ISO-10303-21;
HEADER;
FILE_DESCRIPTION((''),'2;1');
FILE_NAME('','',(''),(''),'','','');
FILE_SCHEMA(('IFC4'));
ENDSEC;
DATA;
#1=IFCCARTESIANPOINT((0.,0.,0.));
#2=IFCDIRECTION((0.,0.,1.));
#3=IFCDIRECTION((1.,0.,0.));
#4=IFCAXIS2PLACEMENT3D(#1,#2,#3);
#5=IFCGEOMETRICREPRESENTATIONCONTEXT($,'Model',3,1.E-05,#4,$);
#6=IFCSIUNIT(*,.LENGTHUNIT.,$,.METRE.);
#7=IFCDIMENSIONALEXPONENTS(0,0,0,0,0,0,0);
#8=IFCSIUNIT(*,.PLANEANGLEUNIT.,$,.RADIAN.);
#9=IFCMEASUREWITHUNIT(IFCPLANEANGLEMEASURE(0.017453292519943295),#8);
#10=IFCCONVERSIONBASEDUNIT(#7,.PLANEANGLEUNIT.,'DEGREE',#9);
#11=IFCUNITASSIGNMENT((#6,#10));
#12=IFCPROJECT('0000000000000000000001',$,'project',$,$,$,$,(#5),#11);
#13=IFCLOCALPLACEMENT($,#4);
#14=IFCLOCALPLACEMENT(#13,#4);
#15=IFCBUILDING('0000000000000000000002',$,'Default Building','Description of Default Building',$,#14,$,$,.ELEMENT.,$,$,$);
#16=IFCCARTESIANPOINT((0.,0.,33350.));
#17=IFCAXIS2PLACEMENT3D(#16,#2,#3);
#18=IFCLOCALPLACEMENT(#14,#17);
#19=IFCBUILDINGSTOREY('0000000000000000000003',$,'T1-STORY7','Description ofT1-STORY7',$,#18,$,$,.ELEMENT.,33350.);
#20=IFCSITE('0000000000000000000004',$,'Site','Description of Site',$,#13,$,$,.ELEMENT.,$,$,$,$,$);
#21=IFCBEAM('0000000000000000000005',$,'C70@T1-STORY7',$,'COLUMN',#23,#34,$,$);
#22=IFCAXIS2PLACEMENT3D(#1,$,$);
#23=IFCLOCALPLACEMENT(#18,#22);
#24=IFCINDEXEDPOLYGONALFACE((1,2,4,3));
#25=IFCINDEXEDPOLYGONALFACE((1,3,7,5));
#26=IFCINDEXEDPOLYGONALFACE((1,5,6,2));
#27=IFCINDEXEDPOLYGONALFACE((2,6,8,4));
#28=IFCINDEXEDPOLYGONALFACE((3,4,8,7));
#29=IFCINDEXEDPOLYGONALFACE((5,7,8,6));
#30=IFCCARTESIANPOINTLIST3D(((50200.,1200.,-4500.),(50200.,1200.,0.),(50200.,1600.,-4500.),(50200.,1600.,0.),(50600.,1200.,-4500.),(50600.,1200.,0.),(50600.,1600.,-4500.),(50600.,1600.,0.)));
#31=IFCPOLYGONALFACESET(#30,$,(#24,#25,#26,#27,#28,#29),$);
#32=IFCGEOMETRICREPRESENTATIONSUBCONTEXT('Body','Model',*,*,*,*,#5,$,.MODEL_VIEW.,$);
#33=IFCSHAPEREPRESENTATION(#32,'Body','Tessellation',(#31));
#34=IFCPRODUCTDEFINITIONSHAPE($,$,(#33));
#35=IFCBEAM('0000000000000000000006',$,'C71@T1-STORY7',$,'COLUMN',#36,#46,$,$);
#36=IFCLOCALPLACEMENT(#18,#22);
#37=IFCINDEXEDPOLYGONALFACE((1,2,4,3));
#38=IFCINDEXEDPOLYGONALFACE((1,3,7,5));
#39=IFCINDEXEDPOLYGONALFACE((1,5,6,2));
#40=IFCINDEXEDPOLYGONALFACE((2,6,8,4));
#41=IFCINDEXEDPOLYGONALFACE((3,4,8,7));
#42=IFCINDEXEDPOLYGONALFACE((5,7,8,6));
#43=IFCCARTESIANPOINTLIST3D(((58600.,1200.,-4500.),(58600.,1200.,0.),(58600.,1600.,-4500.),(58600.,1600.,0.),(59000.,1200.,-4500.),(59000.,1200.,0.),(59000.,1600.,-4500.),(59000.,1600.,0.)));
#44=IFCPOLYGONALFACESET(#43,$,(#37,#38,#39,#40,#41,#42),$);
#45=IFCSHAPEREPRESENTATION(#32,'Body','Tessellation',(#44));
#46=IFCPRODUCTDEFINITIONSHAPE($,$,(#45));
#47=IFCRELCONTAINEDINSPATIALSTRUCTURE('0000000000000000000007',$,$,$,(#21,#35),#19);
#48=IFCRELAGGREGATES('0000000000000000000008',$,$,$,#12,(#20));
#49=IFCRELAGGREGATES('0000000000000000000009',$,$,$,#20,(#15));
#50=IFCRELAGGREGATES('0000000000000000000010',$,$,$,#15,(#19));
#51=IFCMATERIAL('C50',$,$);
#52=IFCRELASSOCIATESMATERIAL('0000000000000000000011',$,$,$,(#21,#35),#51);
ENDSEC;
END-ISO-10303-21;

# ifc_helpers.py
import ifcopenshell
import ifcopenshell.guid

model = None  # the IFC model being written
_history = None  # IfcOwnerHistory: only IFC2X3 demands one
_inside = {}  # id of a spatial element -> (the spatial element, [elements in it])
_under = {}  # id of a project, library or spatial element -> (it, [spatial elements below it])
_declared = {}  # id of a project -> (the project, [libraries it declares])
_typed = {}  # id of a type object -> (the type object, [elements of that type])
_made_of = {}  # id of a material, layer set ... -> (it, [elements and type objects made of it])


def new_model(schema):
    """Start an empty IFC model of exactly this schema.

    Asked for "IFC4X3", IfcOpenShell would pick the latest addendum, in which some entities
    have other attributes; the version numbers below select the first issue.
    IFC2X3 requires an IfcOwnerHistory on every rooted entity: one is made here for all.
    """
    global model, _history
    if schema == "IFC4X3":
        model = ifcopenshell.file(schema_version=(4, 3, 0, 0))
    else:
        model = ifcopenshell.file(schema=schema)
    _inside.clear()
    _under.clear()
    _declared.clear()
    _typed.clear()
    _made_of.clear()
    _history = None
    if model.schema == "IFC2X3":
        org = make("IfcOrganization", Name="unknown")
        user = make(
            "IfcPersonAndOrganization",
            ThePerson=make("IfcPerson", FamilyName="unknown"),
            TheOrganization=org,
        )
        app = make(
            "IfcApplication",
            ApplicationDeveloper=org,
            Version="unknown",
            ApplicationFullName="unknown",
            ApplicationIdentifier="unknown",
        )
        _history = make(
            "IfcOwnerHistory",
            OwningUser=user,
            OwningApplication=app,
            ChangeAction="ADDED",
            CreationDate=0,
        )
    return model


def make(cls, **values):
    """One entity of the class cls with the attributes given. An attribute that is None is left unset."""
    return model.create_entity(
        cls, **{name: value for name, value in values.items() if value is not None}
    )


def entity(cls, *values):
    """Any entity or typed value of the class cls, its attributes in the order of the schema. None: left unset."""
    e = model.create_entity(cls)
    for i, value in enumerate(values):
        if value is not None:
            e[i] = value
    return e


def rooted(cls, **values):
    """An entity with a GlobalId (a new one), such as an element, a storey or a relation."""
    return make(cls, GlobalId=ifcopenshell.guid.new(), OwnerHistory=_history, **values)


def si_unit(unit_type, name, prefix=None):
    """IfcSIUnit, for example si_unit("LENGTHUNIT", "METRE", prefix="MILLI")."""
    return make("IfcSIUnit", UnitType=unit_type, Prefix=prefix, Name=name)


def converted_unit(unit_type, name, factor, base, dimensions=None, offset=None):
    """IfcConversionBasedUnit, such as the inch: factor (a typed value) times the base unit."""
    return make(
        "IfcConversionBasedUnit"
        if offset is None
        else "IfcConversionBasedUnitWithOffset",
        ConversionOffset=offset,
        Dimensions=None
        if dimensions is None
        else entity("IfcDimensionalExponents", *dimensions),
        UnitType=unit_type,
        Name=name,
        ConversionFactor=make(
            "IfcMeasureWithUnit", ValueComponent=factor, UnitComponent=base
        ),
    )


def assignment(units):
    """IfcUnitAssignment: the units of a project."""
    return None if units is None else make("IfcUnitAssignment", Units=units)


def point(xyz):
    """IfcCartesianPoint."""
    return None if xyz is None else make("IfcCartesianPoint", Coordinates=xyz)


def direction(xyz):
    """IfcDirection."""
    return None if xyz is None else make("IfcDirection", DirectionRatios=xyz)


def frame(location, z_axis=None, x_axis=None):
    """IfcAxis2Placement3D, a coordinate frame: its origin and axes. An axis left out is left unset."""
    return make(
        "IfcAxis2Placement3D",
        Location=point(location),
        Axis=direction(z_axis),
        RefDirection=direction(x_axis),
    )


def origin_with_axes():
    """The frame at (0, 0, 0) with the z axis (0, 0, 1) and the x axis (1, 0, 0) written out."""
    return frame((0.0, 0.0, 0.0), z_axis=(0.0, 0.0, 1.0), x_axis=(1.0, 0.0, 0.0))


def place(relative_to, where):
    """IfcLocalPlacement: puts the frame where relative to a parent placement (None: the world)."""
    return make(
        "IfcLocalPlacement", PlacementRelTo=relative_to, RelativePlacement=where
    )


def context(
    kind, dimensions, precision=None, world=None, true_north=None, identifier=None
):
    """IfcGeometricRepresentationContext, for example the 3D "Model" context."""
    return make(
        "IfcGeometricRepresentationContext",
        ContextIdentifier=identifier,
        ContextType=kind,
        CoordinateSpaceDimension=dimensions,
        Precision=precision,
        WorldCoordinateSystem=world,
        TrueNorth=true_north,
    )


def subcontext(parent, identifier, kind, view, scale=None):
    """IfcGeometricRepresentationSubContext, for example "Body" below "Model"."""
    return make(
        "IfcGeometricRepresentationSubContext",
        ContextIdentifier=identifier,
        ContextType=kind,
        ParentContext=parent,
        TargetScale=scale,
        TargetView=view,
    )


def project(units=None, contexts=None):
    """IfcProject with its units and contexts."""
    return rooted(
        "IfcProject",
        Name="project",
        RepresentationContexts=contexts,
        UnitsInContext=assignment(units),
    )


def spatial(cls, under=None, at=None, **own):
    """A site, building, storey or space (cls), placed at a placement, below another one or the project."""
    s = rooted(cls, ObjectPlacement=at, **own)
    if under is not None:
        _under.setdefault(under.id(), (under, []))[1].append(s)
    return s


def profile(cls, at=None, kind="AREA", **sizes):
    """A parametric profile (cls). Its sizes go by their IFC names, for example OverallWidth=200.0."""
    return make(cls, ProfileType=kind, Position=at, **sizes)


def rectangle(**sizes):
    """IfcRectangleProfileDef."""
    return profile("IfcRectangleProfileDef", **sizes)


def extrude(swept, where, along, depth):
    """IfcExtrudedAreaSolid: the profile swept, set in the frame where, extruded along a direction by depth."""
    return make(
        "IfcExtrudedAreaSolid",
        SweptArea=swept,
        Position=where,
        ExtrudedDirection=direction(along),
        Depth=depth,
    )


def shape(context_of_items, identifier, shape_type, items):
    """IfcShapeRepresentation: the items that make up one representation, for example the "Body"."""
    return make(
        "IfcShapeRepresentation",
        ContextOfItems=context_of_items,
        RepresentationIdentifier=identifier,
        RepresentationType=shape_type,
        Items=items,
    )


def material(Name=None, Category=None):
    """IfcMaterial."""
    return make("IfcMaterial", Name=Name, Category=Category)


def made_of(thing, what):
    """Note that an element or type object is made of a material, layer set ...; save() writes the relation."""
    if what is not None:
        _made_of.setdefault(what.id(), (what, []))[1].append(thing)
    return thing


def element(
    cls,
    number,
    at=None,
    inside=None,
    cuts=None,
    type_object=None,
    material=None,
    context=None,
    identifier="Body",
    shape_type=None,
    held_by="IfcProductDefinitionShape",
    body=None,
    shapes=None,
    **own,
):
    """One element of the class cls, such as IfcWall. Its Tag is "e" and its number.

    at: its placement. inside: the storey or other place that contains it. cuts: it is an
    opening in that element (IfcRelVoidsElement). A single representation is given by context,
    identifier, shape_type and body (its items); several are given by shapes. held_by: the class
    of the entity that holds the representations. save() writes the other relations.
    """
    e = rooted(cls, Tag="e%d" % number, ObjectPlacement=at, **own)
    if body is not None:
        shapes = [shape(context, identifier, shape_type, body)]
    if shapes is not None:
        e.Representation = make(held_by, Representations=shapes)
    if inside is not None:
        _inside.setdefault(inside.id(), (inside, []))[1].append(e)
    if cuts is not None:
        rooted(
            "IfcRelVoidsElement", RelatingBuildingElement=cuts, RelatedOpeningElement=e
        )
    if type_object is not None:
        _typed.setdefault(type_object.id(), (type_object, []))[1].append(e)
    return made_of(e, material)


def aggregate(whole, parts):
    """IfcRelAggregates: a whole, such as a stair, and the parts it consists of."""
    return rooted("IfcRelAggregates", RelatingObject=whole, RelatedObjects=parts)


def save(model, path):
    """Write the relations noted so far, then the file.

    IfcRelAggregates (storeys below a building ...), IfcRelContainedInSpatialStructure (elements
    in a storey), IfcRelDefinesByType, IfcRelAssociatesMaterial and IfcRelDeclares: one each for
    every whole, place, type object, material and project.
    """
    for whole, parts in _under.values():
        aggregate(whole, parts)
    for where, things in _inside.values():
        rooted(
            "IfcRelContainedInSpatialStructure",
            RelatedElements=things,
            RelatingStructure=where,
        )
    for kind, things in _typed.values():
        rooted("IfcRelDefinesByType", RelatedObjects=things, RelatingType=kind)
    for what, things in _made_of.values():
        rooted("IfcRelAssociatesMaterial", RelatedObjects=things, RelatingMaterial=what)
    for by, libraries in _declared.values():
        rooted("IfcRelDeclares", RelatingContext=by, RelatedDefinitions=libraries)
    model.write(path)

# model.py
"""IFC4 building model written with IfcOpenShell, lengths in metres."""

from ifc_helpers import new_model, entity, si_unit, converted_unit, frame, origin_with_axes, place, context, subcontext, project, spatial, rectangle, extrude, material, element, save


model = new_model("IFC4")

# Units and contexts
model_context = context("Model", 3, precision=1e-05, world=origin_with_axes())
body_context = subcontext(model_context, "Body", "Model", "MODEL_VIEW")
ifc_project = project(units=[si_unit("LENGTHUNIT", "METRE"), converted_unit("PLANEANGLEUNIT", "DEGREE", entity("IfcPlaneAngleMeasure", 0.017453292519943295), si_unit("PLANEANGLEUNIT", "RADIAN"), dimensions=[0, 0, 0, 0, 0, 0, 0])], contexts=[model_context])

# Site, building, storey
site_placement = place(None, origin_with_axes())
site = spatial("IfcSite", under=ifc_project, at=site_placement, Name="Site", Description="Description of Site", CompositionType="ELEMENT")
building_placement = place(site_placement, origin_with_axes())
building = spatial("IfcBuilding", under=site, at=building_placement, Name="Default Building", Description="Description of Default Building", CompositionType="ELEMENT")
storey_placement = place(building_placement, frame((0.0, 0.0, 33350.0), z_axis=(0.0, 0.0, 1.0), x_axis=(1.0, 0.0, 0.0)))
storey = spatial("IfcBuildingStorey", under=building, at=storey_placement, Name="T1-STORY7", Description="Description ofT1-STORY7", CompositionType="ELEMENT", Elevation=33350.0)

# Beams
ifc_material_1 = material(Name="C50")
for number, where, z_axis, x_axis, name in (
    (1, (50400.0, 1400.0, -4500.0), (0.0, 0.0, 1.0), (-1.0, 0.0, 0.0), "C70@T1-STORY7"),
    (2, (58800.0, 1400.0, -4500.0), (0.0, 0.0, 1.0), (-1.0, 0.0, 0.0), "C71@T1-STORY7"),
):
    element("IfcBeam", number, at=place(storey_placement, frame(where, z_axis=z_axis, x_axis=x_axis)), inside=storey, material=ifc_material_1, Name=name, ObjectType="COLUMN", context=body_context, shape_type="SweptSolid", body=[
        extrude(rectangle(XDim=400.0, YDim=400.0), origin_with_axes(), (0.0, 0.0, 1.0), 4500.0),
    ])

save(model, "model.ifc")
